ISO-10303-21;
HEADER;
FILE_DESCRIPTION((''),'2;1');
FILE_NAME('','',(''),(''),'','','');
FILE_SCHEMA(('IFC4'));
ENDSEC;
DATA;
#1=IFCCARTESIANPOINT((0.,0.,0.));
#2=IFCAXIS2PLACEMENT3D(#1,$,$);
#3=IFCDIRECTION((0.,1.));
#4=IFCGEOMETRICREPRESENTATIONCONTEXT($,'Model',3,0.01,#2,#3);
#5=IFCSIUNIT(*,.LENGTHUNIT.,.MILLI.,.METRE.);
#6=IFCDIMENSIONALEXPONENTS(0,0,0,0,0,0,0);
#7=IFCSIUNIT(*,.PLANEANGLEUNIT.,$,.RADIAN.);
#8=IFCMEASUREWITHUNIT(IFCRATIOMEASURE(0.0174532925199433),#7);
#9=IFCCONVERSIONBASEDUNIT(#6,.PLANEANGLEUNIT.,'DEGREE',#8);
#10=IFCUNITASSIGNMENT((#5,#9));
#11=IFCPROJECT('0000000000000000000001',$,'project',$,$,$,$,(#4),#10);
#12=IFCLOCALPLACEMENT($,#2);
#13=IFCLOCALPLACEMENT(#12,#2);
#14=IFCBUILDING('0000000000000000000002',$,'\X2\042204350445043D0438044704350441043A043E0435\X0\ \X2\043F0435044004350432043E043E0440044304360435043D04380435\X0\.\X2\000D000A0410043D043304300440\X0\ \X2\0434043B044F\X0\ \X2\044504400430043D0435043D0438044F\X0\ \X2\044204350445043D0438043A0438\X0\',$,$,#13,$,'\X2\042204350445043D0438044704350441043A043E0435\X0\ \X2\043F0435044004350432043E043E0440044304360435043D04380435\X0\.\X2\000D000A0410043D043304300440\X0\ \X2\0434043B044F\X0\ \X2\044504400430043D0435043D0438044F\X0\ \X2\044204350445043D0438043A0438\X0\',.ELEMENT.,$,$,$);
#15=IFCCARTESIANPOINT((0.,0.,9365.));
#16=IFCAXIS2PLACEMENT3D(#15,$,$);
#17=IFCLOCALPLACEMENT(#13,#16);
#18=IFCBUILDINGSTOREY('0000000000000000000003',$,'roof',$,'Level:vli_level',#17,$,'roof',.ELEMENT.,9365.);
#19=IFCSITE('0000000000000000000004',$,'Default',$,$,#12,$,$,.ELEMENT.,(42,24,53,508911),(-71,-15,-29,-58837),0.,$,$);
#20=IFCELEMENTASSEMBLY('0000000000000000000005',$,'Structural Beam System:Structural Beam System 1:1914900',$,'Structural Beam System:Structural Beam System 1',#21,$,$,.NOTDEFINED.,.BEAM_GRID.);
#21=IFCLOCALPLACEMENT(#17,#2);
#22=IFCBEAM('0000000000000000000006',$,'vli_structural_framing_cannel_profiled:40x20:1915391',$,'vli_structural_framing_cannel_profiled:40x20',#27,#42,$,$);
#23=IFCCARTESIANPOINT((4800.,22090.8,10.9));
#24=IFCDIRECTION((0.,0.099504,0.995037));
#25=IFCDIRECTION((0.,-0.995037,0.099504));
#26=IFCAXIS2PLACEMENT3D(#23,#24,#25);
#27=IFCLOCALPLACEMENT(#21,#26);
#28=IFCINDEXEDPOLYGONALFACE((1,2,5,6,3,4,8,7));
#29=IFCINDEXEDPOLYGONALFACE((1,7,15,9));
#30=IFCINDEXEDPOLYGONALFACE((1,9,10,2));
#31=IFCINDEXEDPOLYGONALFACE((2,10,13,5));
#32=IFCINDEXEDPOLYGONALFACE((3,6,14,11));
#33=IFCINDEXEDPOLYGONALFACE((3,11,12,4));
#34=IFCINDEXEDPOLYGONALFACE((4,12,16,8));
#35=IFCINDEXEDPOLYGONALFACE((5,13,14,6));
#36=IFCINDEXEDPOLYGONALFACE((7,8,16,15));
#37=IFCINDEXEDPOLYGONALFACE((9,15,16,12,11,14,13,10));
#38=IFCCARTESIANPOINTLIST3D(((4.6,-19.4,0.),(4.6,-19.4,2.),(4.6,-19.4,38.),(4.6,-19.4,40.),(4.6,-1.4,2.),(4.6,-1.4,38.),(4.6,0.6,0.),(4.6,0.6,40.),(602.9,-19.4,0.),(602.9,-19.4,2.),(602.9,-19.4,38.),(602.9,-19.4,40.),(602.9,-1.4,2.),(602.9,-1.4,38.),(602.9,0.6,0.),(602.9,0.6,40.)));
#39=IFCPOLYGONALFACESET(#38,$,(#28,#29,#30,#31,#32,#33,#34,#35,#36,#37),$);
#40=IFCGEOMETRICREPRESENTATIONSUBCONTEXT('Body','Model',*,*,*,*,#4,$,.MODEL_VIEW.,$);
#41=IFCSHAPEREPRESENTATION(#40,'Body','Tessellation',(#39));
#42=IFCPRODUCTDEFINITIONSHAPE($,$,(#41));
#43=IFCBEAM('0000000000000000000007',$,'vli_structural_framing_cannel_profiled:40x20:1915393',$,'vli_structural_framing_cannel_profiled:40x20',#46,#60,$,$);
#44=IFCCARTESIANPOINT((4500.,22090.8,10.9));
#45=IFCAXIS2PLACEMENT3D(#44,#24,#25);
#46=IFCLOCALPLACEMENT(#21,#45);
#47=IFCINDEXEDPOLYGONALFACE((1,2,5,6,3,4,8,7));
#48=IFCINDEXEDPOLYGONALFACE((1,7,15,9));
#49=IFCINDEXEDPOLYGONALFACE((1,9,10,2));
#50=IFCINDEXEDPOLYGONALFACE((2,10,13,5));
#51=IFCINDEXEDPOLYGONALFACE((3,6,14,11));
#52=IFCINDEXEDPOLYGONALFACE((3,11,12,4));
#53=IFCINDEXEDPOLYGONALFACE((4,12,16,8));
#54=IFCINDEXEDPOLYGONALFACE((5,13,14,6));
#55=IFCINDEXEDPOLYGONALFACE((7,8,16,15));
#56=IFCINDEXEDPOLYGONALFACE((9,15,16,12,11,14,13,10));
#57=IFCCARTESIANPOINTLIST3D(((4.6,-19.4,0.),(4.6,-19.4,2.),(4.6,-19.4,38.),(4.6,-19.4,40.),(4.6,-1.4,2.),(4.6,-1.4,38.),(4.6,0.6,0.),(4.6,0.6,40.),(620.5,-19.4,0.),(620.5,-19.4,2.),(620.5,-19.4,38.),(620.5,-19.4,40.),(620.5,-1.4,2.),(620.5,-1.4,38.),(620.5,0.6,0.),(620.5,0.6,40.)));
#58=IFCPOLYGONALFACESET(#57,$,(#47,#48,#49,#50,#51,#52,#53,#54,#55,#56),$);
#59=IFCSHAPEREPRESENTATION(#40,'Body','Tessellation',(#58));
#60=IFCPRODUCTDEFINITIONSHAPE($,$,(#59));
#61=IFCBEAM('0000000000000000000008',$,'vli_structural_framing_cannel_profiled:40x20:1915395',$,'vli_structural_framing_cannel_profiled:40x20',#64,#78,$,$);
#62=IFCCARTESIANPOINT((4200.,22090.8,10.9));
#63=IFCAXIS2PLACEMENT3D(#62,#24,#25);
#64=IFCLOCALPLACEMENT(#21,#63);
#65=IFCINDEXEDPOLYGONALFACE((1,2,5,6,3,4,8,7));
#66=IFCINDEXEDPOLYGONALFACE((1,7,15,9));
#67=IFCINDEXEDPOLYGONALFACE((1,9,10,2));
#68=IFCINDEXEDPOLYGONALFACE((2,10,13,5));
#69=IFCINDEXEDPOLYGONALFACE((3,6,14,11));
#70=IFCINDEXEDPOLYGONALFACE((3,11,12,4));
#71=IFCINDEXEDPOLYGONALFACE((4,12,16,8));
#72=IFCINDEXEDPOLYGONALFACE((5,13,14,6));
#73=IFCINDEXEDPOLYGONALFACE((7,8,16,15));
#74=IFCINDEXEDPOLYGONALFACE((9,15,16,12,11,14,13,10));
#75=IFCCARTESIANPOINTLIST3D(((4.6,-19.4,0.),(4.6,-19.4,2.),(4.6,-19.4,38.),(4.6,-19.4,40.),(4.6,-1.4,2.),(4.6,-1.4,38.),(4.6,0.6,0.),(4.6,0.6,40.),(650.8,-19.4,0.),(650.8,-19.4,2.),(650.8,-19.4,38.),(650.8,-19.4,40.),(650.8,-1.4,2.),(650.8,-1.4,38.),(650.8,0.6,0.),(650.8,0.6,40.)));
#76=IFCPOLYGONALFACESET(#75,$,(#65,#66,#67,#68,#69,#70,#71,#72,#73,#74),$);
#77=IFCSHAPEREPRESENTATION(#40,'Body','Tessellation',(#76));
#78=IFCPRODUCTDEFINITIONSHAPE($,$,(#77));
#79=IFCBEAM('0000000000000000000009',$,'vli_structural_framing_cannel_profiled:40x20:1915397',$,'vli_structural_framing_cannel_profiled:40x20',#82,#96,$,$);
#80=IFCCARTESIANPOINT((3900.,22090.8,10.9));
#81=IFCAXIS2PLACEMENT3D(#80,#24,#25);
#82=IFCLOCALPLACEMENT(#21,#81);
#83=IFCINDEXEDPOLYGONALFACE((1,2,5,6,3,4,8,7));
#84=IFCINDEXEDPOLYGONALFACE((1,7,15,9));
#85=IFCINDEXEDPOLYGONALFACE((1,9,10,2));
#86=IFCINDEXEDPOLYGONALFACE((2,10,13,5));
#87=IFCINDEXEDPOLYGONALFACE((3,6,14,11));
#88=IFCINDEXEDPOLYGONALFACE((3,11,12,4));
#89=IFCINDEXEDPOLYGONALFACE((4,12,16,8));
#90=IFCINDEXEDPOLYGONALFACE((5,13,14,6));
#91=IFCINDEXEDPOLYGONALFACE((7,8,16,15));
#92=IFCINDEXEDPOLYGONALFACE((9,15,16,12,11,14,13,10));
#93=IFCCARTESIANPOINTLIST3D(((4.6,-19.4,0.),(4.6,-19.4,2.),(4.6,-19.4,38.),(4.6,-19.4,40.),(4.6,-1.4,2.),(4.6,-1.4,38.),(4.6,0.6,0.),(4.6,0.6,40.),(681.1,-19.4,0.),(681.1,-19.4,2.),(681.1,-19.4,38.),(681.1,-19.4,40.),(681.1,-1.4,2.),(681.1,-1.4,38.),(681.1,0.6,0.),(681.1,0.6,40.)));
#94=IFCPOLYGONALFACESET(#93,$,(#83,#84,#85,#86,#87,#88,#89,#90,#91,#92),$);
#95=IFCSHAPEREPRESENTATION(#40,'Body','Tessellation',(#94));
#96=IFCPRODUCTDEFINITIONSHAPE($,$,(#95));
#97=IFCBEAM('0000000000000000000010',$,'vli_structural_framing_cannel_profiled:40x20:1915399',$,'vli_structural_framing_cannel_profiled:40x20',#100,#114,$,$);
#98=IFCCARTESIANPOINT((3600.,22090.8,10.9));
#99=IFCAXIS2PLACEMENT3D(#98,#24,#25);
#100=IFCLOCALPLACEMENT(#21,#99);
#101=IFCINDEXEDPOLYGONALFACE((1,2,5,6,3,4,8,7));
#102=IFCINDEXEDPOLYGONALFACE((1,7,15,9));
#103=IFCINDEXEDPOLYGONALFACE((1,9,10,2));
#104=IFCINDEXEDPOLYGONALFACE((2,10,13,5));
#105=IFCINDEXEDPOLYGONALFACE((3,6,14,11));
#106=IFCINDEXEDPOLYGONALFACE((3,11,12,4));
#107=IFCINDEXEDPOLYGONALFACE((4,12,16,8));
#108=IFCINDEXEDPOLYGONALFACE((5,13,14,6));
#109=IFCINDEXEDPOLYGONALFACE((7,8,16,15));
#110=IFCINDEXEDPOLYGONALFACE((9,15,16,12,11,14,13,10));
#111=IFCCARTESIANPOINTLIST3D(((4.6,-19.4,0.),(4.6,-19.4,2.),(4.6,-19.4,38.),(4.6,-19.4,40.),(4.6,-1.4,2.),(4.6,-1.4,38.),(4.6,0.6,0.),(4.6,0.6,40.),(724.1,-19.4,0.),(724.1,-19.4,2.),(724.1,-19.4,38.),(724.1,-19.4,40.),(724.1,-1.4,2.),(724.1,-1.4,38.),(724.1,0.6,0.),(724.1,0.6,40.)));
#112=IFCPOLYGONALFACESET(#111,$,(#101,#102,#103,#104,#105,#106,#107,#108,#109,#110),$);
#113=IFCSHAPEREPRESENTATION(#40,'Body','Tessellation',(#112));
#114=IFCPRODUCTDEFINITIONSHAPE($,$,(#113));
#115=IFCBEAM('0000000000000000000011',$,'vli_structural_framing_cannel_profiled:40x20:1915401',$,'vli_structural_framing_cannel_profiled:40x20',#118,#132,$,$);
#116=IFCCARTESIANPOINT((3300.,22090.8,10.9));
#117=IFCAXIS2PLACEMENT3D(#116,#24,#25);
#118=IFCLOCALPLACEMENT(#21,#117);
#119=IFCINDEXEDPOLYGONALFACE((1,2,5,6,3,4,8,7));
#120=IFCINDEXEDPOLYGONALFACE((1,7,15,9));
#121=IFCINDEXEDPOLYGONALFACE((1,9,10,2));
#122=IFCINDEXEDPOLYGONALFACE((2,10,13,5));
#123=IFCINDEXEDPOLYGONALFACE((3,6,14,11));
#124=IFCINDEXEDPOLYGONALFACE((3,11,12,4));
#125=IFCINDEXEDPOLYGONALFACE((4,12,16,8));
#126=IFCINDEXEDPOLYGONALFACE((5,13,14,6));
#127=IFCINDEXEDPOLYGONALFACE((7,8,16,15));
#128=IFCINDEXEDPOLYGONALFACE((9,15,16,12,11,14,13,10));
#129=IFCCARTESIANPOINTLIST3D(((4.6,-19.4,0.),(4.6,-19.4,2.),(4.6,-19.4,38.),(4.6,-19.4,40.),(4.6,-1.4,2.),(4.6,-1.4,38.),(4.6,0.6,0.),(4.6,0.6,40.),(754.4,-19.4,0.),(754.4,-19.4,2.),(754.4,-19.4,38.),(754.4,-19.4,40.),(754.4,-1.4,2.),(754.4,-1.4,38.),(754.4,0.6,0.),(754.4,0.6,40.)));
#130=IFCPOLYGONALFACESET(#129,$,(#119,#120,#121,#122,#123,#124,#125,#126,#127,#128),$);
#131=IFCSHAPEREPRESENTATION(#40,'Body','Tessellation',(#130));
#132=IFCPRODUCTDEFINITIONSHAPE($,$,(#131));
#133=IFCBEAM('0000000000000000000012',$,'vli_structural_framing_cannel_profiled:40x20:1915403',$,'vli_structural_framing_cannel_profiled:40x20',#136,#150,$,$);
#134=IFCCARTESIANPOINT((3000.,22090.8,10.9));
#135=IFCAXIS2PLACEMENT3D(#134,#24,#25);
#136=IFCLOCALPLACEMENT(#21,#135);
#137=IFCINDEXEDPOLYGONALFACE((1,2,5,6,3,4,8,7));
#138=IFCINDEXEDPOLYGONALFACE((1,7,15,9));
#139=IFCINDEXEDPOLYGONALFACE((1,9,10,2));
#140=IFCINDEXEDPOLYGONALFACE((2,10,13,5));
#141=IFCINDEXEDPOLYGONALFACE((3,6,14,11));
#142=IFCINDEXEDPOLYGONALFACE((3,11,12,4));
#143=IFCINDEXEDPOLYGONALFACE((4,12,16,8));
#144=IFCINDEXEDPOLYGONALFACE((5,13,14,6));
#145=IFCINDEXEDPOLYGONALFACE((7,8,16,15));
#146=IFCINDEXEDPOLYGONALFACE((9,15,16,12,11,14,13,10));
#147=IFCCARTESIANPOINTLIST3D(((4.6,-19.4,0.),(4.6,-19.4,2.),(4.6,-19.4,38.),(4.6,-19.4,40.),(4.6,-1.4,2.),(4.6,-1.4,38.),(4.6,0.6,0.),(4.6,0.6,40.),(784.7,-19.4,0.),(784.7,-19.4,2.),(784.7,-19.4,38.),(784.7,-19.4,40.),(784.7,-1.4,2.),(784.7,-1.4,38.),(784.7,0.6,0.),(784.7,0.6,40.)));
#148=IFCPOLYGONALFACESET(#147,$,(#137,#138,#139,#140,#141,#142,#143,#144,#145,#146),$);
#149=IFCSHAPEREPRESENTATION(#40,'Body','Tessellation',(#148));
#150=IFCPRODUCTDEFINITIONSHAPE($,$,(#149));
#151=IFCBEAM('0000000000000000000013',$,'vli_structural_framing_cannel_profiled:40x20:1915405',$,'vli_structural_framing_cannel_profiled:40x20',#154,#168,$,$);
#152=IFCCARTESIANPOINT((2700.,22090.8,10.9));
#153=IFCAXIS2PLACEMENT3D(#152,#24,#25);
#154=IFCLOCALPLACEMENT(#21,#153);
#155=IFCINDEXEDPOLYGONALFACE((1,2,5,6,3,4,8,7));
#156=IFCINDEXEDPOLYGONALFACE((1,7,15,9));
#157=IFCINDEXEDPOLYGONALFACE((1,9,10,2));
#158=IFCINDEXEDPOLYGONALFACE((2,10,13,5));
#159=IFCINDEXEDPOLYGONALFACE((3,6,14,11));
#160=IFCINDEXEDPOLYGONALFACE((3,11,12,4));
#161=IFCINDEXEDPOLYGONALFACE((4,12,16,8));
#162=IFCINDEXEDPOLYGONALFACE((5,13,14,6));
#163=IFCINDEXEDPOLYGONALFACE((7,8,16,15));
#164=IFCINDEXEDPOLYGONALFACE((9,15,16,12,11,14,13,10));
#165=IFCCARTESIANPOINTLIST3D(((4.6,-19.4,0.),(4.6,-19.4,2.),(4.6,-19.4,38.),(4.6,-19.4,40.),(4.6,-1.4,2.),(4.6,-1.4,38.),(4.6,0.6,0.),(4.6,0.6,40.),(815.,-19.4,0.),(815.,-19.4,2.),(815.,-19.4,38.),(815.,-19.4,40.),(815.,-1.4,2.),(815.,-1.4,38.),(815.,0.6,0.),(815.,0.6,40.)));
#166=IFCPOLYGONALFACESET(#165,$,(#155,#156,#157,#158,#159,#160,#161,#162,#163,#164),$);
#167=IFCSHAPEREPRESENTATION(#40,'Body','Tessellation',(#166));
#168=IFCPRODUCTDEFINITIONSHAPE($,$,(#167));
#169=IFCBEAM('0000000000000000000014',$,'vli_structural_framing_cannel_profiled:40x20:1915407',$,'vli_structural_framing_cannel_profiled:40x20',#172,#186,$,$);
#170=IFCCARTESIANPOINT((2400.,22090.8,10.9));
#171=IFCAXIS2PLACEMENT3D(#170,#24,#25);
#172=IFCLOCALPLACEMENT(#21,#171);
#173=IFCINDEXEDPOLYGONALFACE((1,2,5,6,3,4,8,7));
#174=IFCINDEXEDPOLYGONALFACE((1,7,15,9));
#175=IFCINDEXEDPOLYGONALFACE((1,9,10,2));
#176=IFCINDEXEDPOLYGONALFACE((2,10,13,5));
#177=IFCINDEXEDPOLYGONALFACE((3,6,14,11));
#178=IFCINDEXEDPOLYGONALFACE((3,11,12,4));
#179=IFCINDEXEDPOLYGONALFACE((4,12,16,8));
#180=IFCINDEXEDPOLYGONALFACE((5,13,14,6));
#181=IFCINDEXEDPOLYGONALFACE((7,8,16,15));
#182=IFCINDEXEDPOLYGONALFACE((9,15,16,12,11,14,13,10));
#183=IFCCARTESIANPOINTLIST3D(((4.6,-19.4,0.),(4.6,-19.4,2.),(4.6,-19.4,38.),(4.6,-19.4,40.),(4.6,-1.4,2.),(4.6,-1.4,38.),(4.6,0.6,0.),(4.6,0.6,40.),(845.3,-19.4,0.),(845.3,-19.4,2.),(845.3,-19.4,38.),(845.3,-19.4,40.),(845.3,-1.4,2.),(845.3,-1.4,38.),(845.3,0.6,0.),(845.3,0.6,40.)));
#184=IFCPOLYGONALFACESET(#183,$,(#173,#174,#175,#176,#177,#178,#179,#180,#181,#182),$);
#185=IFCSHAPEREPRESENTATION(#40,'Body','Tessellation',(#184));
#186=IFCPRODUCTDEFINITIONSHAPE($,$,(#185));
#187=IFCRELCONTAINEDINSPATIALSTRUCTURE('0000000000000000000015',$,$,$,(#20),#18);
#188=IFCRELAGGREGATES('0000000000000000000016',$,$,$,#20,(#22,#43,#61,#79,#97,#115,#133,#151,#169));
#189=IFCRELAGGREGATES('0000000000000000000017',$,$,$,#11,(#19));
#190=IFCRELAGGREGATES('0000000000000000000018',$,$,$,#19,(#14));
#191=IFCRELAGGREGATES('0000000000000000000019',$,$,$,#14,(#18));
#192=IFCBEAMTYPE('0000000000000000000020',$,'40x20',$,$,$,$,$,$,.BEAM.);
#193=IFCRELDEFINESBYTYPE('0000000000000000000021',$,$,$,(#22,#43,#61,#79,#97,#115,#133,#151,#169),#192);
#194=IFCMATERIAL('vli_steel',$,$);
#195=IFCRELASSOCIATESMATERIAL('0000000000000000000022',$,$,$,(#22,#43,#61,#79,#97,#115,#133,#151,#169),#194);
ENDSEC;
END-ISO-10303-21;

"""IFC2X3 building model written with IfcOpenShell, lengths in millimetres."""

from ifc_helpers import new_model, entity, si_unit, converted_unit, direction, frame, origin, place, context, subcontext, project, spatial, polyline, outline, extrude, material, type_object, element, aggregate, save


model = new_model("IFC2X3")

# Units and contexts
model_context = context("Model", 3, precision=0.01, world=origin(), true_north=direction((0.0, 1.0)))
body_context = subcontext(model_context, "Body", "Model", "MODEL_VIEW")
ifc_project = project(units=[si_unit("LENGTHUNIT", "METRE", prefix="MILLI"), converted_unit("PLANEANGLEUNIT", "DEGREE", entity("IfcRatioMeasure", 0.0174532925199433), si_unit("PLANEANGLEUNIT", "RADIAN"), dimensions=[0, 0, 0, 0, 0, 0, 0])], contexts=[model_context])

# Site, building, storey
site_placement = place(None, origin())
site = spatial("IfcSite", under=ifc_project, at=site_placement, Name="Default", CompositionType="ELEMENT", RefLatitude=(42, 24, 53, 508911), RefLongitude=(-71, -15, -29, -58837), RefElevation=0.0)
building_placement = place(site_placement, origin())
building = spatial("IfcBuilding", under=site, at=building_placement, Name="Техническое перевооружение.\r\nАнгар для хранения техники", LongName="Техническое перевооружение.\r\nАнгар для хранения техники", CompositionType="ELEMENT")
storey_placement = place(building_placement, frame((0.0, 0.0, 9365.0)))
storey = spatial("IfcBuildingStorey", under=building, at=storey_placement, Name="roof", ObjectType="Level:vli_level", LongName="roof", CompositionType="ELEMENT", Elevation=9365.0)

# Element assembly, beams
assembly_1_placement = place(storey_placement, origin())
assembly_1 = element("IfcElementAssembly", 1, at=assembly_1_placement, inside=storey, Name="Structural Beam System:Structural Beam System 1:1914900", ObjectType="Structural Beam System:Structural Beam System 1", AssemblyPlace="NOTDEFINED", PredefinedType="BEAM_GRID")
ifc_material = material(Name="vli_steel")
beam_type = type_object("IfcBeamType", Name="40x20", PredefinedType="BEAM")
beam_1_placement = place(assembly_1_placement, frame((4800.0, 22090.8, 10.9), z_axis=(0.0, 0.099504, 0.995037), x_axis=(0.0, -0.995037, 0.099504)))
beam_1 = element("IfcBeam", 2, at=beam_1_placement, type_object=beam_type, material=ifc_material, Name="vli_structural_framing_cannel_profiled:40x20:1915391", ObjectType="vli_structural_framing_cannel_profiled:40x20", context=body_context, shape_type="SweptSolid", body=[
    extrude(outline(polyline([(-20.0, -9.5), (-18.0, -9.5), (-18.0, 8.5), (18.0, 8.5), (18.0, -9.5), (20.0, -9.5), (20.0, 10.5), (-20.0, 10.5), (-20.0, -9.5)])), frame((4.6, -9.9, 20.0), z_axis=(1.0, 0.0, 0.0), x_axis=(0.0, 0.0, -1.0)), (0.0, 0.0, 1.0), 598.3),
])
beam_2_placement = place(assembly_1_placement, frame((4500.0, 22090.8, 10.9), z_axis=(0.0, 0.099504, 0.995037), x_axis=(0.0, -0.995037, 0.099504)))
beam_2 = element("IfcBeam", 3, at=beam_2_placement, type_object=beam_type, material=ifc_material, Name="vli_structural_framing_cannel_profiled:40x20:1915393", ObjectType="vli_structural_framing_cannel_profiled:40x20", context=body_context, shape_type="SweptSolid", body=[
    extrude(outline(polyline([(-20.0, -9.5), (-18.0, -9.5), (-18.0, 8.5), (18.0, 8.5), (18.0, -9.5), (20.0, -9.5), (20.0, 10.5), (-20.0, 10.5), (-20.0, -9.5)])), frame((4.6, -9.9, 20.0), z_axis=(1.0, 0.0, 0.0), x_axis=(0.0, 0.0, -1.0)), (0.0, 0.0, 1.0), 615.9),
])
beam_3_placement = place(assembly_1_placement, frame((4200.0, 22090.8, 10.9), z_axis=(0.0, 0.099504, 0.995037), x_axis=(0.0, -0.995037, 0.099504)))
beam_3 = element("IfcBeam", 4, at=beam_3_placement, type_object=beam_type, material=ifc_material, Name="vli_structural_framing_cannel_profiled:40x20:1915395", ObjectType="vli_structural_framing_cannel_profiled:40x20", context=body_context, shape_type="SweptSolid", body=[
    extrude(outline(polyline([(-20.0, -9.5), (-18.0, -9.5), (-18.0, 8.5), (18.0, 8.5), (18.0, -9.5), (20.0, -9.5), (20.0, 10.5), (-20.0, 10.5), (-20.0, -9.5)])), frame((4.6, -9.9, 20.0), z_axis=(1.0, 0.0, 0.0), x_axis=(0.0, 0.0, -1.0)), (0.0, 0.0, 1.0), 646.2),
])
beam_4_placement = place(assembly_1_placement, frame((3900.0, 22090.8, 10.9), z_axis=(0.0, 0.099504, 0.995037), x_axis=(0.0, -0.995037, 0.099504)))
beam_4 = element("IfcBeam", 5, at=beam_4_placement, type_object=beam_type, material=ifc_material, Name="vli_structural_framing_cannel_profiled:40x20:1915397", ObjectType="vli_structural_framing_cannel_profiled:40x20", context=body_context, shape_type="SweptSolid", body=[
    extrude(outline(polyline([(-20.0, -9.5), (-18.0, -9.5), (-18.0, 8.5), (18.0, 8.5), (18.0, -9.5), (20.0, -9.5), (20.0, 10.5), (-20.0, 10.5), (-20.0, -9.5)])), frame((4.6, -9.9, 20.0), z_axis=(1.0, 0.0, 0.0), x_axis=(0.0, 0.0, -1.0)), (0.0, 0.0, 1.0), 676.5),
])
beam_5_placement = place(assembly_1_placement, frame((3600.0, 22090.8, 10.9), z_axis=(0.0, 0.099504, 0.995037), x_axis=(0.0, -0.995037, 0.099504)))
beam_5 = element("IfcBeam", 6, at=beam_5_placement, type_object=beam_type, material=ifc_material, Name="vli_structural_framing_cannel_profiled:40x20:1915399", ObjectType="vli_structural_framing_cannel_profiled:40x20", context=body_context, shape_type="SweptSolid", body=[
    extrude(outline(polyline([(-20.0, -9.5), (-18.0, -9.5), (-18.0, 8.5), (18.0, 8.5), (18.0, -9.5), (20.0, -9.5), (20.0, 10.5), (-20.0, 10.5), (-20.0, -9.5)])), frame((4.6, -9.9, 20.0), z_axis=(1.0, 0.0, 0.0), x_axis=(0.0, 0.0, -1.0)), (0.0, 0.0, 1.0), 719.5),
])
beam_6_placement = place(assembly_1_placement, frame((3300.0, 22090.8, 10.9), z_axis=(0.0, 0.099504, 0.995037), x_axis=(0.0, -0.995037, 0.099504)))
beam_6 = element("IfcBeam", 7, at=beam_6_placement, type_object=beam_type, material=ifc_material, Name="vli_structural_framing_cannel_profiled:40x20:1915401", ObjectType="vli_structural_framing_cannel_profiled:40x20", context=body_context, shape_type="SweptSolid", body=[
    extrude(outline(polyline([(-20.0, -9.5), (-18.0, -9.5), (-18.0, 8.5), (18.0, 8.5), (18.0, -9.5), (20.0, -9.5), (20.0, 10.5), (-20.0, 10.5), (-20.0, -9.5)])), frame((4.6, -9.9, 20.0), z_axis=(1.0, 0.0, 0.0), x_axis=(0.0, 0.0, -1.0)), (0.0, 0.0, 1.0), 749.8),
])
beam_7_placement = place(assembly_1_placement, frame((3000.0, 22090.8, 10.9), z_axis=(0.0, 0.099504, 0.995037), x_axis=(0.0, -0.995037, 0.099504)))
beam_7 = element("IfcBeam", 8, at=beam_7_placement, type_object=beam_type, material=ifc_material, Name="vli_structural_framing_cannel_profiled:40x20:1915403", ObjectType="vli_structural_framing_cannel_profiled:40x20", context=body_context, shape_type="SweptSolid", body=[
    extrude(outline(polyline([(-20.0, -9.5), (-18.0, -9.5), (-18.0, 8.5), (18.0, 8.5), (18.0, -9.5), (20.0, -9.5), (20.0, 10.5), (-20.0, 10.5), (-20.0, -9.5)])), frame((4.6, -9.9, 20.0), z_axis=(1.0, 0.0, 0.0), x_axis=(0.0, 0.0, -1.0)), (0.0, 0.0, 1.0), 780.2),
])
beam_8_placement = place(assembly_1_placement, frame((2700.0, 22090.8, 10.9), z_axis=(0.0, 0.099504, 0.995037), x_axis=(0.0, -0.995037, 0.099504)))
beam_8 = element("IfcBeam", 9, at=beam_8_placement, type_object=beam_type, material=ifc_material, Name="vli_structural_framing_cannel_profiled:40x20:1915405", ObjectType="vli_structural_framing_cannel_profiled:40x20", context=body_context, shape_type="SweptSolid", body=[
    extrude(outline(polyline([(-20.0, -9.5), (-18.0, -9.5), (-18.0, 8.5), (18.0, 8.5), (18.0, -9.5), (20.0, -9.5), (20.0, 10.5), (-20.0, 10.5), (-20.0, -9.5)])), frame((4.6, -9.9, 20.0), z_axis=(1.0, 0.0, 0.0), x_axis=(0.0, 0.0, -1.0)), (0.0, 0.0, 1.0), 810.5),
])
beam_9_placement = place(assembly_1_placement, frame((2400.0, 22090.8, 10.9), z_axis=(0.0, 0.099504, 0.995037), x_axis=(0.0, -0.995037, 0.099504)))
beam_9 = element("IfcBeam", 10, at=beam_9_placement, type_object=beam_type, material=ifc_material, Name="vli_structural_framing_cannel_profiled:40x20:1915407", ObjectType="vli_structural_framing_cannel_profiled:40x20", context=body_context, shape_type="SweptSolid", body=[
    extrude(outline(polyline([(-20.0, -9.5), (-18.0, -9.5), (-18.0, 8.5), (18.0, 8.5), (18.0, -9.5), (20.0, -9.5), (20.0, 10.5), (-20.0, 10.5), (-20.0, -9.5)])), frame((4.6, -9.9, 20.0), z_axis=(1.0, 0.0, 0.0), x_axis=(0.0, 0.0, -1.0)), (0.0, 0.0, 1.0), 840.8),
])
aggregate(assembly_1, [beam_1, beam_2, beam_3, beam_4, beam_5, beam_6, beam_7, beam_8, beam_9])

save(model, "model.ifc")
